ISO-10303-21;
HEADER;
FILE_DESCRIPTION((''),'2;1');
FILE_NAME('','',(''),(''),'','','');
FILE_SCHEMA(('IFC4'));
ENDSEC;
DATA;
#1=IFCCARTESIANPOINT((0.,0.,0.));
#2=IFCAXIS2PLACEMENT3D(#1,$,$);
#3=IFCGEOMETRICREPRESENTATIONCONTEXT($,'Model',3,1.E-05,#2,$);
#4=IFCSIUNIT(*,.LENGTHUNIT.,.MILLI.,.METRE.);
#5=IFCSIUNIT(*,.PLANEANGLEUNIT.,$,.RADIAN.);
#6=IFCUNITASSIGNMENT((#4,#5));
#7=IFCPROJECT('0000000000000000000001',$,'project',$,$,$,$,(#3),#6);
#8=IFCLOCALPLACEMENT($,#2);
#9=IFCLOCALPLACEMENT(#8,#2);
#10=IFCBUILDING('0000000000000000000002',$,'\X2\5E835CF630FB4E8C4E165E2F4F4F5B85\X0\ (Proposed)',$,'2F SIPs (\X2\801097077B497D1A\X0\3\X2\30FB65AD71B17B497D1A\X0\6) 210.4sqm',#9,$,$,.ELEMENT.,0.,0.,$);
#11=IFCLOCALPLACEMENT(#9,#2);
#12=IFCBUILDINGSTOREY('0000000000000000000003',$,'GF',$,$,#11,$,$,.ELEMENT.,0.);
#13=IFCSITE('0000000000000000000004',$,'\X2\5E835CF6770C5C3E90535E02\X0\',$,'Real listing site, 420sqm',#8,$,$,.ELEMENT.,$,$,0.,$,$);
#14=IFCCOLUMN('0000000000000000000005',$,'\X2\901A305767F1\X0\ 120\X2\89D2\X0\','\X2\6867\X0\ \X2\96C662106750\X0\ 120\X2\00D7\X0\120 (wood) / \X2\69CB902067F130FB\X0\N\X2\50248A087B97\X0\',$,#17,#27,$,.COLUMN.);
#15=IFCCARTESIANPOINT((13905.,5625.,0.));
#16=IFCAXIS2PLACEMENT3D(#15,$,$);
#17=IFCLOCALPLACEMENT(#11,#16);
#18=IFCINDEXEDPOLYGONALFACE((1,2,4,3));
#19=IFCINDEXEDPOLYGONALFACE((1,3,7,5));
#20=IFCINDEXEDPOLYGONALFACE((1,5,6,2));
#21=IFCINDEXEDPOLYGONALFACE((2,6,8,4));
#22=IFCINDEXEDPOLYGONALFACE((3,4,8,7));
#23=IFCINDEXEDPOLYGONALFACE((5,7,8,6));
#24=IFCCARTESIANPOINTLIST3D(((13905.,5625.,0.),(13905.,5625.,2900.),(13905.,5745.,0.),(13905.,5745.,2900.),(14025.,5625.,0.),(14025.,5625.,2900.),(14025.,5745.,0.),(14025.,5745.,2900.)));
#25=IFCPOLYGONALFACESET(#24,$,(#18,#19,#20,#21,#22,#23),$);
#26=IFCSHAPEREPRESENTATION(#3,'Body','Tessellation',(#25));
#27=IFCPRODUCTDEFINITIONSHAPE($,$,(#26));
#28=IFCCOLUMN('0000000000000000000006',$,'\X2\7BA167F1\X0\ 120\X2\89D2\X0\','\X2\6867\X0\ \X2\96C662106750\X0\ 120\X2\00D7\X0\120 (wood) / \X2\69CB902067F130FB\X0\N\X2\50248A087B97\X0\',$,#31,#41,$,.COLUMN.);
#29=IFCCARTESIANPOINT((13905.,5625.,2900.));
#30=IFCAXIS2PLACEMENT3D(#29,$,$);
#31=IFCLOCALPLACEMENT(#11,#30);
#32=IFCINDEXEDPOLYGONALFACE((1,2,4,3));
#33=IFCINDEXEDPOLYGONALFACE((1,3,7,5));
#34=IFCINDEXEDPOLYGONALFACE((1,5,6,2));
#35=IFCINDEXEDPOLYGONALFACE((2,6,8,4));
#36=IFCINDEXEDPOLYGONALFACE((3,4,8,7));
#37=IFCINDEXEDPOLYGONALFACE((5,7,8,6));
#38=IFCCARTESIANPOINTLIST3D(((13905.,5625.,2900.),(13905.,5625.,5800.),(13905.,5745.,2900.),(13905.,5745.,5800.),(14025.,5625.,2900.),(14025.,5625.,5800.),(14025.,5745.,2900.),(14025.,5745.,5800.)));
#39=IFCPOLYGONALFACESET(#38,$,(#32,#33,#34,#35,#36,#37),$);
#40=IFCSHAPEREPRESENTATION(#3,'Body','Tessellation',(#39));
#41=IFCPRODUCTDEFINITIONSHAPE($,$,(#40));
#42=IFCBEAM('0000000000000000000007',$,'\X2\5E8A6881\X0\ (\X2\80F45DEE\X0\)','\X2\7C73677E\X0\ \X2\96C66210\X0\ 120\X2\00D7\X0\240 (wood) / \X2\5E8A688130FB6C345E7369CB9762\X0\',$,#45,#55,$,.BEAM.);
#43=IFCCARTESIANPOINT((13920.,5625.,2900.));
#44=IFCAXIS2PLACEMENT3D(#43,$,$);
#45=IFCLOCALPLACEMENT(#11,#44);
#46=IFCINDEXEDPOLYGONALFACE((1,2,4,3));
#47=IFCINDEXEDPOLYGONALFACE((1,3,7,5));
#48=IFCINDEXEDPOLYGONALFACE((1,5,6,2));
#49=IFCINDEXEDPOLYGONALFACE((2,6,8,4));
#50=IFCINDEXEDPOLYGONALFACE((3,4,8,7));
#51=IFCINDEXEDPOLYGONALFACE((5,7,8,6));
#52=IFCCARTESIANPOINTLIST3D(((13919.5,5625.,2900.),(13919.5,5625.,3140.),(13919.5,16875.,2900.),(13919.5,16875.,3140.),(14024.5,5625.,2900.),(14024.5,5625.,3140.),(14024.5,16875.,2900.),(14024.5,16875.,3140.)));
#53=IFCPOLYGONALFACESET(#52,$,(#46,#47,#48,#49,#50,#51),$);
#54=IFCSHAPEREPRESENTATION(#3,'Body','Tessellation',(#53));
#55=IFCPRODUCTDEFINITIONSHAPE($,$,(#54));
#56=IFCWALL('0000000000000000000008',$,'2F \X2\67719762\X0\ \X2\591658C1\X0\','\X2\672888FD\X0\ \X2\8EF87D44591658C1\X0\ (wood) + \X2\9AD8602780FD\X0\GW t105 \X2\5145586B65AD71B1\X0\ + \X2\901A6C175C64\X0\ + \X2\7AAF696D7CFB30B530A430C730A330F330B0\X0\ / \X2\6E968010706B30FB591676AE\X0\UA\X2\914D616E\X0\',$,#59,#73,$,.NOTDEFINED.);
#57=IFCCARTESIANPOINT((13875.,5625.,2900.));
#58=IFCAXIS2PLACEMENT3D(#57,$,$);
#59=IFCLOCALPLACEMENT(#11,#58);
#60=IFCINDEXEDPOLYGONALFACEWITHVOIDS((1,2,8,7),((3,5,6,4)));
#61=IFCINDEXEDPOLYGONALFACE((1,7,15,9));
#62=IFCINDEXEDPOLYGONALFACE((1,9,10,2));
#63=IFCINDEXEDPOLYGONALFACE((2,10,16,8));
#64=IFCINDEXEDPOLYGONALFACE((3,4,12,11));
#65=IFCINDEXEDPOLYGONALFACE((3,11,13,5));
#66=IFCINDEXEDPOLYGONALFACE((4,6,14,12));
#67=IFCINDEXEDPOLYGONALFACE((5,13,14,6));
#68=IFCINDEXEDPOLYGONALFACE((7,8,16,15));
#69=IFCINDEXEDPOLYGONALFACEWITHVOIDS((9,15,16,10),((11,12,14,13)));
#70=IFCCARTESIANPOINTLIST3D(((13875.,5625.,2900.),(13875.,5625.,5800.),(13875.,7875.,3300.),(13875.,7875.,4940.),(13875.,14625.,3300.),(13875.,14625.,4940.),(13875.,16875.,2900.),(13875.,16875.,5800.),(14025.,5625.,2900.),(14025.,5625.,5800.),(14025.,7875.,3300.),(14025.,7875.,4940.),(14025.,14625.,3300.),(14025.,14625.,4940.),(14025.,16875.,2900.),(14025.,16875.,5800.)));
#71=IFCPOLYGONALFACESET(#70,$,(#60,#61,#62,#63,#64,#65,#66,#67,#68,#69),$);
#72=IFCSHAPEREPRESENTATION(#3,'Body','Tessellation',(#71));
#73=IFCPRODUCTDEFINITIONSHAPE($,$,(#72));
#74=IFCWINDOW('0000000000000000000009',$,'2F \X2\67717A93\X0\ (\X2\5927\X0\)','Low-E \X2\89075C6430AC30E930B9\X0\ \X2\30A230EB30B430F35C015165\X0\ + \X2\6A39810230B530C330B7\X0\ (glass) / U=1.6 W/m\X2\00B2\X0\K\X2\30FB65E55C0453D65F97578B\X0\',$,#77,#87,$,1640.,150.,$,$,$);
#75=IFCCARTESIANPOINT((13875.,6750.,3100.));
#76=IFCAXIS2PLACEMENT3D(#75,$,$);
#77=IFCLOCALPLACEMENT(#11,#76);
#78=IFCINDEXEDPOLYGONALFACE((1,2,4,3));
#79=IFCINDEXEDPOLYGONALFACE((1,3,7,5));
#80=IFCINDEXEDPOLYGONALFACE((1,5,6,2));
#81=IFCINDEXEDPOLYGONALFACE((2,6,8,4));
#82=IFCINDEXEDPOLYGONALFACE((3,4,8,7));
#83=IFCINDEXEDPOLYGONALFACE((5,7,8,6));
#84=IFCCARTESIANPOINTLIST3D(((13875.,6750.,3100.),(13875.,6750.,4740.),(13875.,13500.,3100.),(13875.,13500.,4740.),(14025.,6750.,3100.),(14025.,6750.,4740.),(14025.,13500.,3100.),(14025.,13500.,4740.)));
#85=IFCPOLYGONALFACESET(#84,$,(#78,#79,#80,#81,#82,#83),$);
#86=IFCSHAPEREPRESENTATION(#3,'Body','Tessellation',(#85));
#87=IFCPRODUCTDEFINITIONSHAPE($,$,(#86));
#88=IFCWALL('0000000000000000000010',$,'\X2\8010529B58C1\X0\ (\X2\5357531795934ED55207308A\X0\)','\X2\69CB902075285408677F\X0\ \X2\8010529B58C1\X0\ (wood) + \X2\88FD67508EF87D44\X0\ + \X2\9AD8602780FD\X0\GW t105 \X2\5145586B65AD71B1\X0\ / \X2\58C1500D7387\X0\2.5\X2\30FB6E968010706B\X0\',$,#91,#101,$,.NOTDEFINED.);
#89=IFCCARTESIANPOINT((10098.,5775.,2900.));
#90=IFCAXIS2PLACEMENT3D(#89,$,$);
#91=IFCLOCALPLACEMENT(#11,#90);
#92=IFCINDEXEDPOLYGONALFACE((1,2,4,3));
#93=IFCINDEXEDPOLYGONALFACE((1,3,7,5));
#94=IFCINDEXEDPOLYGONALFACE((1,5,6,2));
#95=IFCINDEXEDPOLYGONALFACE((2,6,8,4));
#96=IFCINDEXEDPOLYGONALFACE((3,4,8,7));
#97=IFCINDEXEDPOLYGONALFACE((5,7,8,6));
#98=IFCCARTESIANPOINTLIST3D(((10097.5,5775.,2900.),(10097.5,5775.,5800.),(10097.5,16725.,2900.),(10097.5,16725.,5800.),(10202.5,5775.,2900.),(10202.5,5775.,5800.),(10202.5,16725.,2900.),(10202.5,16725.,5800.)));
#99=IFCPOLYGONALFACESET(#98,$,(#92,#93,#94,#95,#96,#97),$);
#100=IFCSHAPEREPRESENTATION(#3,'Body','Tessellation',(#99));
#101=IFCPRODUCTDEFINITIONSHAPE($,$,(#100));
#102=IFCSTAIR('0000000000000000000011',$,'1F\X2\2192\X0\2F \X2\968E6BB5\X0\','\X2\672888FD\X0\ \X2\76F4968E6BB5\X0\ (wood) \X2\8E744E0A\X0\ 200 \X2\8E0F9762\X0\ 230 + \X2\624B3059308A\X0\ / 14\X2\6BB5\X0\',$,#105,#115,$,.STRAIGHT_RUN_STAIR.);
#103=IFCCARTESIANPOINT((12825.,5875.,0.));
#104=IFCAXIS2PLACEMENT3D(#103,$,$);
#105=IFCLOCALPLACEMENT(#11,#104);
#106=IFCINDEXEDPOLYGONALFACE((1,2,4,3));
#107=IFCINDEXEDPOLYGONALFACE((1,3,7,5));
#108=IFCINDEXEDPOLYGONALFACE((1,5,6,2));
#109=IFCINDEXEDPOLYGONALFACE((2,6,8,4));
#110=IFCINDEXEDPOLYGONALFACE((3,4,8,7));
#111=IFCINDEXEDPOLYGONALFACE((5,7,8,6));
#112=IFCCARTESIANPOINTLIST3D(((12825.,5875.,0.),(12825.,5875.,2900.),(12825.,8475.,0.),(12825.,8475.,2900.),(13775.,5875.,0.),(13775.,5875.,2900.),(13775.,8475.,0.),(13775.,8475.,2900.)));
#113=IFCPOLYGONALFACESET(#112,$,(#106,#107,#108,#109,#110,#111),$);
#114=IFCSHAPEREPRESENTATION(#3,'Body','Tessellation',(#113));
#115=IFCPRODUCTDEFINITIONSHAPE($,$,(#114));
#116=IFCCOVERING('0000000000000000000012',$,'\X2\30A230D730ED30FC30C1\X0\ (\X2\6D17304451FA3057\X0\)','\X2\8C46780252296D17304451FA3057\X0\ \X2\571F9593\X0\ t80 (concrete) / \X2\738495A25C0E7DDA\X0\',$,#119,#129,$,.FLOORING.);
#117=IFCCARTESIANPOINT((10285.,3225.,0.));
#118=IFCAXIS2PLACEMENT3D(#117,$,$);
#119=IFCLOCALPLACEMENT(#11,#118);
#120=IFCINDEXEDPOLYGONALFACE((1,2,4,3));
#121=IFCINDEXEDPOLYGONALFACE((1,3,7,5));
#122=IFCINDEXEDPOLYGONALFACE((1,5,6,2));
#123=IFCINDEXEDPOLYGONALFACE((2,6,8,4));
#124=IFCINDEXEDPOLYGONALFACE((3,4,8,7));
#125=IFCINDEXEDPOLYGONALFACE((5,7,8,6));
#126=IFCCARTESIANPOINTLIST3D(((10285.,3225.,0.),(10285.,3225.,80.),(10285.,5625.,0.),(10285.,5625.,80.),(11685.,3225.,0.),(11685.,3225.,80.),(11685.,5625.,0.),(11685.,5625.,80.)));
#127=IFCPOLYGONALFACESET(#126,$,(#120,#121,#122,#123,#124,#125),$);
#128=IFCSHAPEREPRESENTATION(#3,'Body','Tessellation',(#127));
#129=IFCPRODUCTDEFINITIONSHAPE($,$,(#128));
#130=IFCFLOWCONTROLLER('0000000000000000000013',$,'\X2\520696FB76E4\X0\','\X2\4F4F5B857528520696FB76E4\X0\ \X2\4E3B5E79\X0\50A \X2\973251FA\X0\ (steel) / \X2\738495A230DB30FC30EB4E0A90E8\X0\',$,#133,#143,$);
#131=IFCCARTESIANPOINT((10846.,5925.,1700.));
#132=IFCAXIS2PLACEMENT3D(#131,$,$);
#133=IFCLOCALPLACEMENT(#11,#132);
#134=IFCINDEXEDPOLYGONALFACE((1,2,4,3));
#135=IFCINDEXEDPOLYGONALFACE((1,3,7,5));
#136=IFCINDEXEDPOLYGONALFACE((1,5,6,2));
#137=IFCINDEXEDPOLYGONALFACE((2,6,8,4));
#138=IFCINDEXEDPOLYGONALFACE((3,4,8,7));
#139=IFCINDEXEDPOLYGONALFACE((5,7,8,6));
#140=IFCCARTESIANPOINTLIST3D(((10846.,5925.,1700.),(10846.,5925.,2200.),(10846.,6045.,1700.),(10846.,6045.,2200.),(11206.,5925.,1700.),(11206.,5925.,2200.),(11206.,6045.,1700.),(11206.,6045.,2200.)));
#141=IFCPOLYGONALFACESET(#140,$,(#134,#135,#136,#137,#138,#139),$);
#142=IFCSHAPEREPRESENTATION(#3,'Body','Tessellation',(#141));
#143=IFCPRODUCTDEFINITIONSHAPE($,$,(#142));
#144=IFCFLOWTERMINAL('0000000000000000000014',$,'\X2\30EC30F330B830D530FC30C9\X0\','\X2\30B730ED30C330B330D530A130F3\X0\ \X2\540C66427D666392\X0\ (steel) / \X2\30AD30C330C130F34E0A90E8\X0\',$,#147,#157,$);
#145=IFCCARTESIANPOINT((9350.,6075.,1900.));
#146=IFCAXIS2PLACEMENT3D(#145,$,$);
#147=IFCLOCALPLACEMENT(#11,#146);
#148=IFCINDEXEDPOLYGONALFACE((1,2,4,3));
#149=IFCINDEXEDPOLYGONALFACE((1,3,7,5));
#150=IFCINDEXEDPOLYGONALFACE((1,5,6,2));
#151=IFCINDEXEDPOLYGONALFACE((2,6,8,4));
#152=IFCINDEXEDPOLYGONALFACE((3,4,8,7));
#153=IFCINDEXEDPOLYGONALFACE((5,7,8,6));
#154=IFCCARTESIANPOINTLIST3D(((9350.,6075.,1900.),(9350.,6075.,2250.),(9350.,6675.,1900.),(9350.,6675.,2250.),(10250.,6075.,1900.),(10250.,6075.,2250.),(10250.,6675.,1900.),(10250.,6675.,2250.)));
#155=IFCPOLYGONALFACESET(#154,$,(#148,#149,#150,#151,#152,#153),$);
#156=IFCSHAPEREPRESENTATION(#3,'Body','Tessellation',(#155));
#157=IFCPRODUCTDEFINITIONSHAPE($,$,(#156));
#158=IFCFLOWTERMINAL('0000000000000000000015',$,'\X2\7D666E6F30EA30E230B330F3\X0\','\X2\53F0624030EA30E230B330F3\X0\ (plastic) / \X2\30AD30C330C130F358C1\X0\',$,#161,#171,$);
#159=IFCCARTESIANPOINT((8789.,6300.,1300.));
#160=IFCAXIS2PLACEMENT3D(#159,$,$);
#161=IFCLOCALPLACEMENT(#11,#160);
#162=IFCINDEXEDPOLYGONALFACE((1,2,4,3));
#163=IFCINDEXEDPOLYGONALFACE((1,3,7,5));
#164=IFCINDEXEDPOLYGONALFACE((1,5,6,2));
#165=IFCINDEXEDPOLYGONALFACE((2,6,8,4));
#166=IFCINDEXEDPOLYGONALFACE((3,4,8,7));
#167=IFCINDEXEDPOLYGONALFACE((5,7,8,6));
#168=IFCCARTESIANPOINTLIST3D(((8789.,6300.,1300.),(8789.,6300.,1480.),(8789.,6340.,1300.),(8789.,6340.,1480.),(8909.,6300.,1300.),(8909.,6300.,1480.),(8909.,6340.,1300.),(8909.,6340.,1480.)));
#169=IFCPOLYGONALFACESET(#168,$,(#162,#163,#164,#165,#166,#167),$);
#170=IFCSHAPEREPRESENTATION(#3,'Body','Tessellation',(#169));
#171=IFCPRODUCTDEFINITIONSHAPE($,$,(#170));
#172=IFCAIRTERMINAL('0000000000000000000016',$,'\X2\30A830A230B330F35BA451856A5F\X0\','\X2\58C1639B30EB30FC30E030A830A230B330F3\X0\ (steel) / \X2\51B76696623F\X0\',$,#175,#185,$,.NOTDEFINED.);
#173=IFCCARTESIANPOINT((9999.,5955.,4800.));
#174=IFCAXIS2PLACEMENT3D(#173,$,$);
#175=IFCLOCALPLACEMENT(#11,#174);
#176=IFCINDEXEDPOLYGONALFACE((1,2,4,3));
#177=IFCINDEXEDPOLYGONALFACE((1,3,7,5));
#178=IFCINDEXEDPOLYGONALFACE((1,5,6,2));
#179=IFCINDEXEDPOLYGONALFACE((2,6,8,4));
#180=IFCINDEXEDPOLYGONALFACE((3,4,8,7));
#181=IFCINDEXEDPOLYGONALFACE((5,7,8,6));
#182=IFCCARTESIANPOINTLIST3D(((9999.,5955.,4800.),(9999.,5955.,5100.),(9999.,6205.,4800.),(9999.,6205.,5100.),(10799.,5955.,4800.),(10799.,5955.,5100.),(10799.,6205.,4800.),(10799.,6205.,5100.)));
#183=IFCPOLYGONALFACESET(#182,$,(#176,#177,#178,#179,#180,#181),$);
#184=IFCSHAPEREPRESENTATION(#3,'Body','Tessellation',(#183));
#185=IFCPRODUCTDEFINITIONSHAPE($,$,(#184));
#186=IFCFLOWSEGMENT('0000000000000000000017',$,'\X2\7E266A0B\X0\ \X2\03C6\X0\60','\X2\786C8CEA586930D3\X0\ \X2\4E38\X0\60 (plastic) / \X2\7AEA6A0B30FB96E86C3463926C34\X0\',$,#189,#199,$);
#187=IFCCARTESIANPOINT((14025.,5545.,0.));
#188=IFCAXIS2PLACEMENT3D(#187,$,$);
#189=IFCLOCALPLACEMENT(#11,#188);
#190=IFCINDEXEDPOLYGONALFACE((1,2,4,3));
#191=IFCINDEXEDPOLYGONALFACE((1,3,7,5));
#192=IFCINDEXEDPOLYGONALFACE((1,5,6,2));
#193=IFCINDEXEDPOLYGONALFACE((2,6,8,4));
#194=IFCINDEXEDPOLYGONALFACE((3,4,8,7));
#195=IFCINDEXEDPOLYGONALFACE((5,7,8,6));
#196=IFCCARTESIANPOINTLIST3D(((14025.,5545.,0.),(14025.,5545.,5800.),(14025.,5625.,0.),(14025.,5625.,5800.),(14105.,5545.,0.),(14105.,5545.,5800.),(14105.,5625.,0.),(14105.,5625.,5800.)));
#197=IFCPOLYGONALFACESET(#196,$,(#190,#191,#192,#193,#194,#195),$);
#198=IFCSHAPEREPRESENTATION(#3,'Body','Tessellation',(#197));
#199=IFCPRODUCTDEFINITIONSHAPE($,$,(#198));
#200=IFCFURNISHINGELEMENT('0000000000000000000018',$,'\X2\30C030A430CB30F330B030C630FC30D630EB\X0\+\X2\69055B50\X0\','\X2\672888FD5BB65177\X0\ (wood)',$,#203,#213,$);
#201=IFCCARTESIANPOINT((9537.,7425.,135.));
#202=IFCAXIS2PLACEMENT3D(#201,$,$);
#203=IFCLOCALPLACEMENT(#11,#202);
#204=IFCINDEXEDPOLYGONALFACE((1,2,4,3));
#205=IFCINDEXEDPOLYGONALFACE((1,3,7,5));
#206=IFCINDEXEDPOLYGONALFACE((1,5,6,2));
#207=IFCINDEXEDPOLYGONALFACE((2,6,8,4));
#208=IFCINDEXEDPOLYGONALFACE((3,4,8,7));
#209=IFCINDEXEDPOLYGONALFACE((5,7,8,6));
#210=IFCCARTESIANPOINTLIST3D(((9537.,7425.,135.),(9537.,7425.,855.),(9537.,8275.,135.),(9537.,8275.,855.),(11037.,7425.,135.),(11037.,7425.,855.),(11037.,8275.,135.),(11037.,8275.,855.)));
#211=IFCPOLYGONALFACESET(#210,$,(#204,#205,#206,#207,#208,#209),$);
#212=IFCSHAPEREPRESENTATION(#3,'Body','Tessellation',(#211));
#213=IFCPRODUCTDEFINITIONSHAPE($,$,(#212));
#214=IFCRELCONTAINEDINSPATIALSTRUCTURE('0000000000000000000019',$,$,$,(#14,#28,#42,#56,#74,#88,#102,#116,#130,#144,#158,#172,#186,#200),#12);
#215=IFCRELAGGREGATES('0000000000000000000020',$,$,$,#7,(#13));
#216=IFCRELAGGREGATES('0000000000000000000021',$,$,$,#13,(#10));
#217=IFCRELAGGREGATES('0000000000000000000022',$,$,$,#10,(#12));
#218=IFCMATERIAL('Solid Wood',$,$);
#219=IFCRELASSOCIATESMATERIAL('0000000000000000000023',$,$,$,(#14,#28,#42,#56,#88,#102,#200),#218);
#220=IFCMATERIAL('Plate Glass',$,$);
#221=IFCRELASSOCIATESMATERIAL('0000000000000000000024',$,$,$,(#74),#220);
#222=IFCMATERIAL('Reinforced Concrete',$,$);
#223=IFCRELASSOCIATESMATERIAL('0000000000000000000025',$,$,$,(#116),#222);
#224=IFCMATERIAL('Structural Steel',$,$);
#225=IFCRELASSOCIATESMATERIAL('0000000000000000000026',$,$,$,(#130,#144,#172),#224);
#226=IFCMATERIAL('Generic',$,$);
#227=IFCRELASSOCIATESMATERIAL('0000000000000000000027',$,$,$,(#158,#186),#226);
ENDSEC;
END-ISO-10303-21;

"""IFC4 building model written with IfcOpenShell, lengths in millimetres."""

from ifc_helpers import new_model, si_unit, frame, frame_2d, origin, place, context, project, spatial, rectangle, extrude, material, element, fill, save


model = new_model("IFC4")

# Units and contexts
model_context = context("Model", 3, precision=1e-05, world=origin())
ifc_project = project(units=[si_unit("LENGTHUNIT", "METRE", prefix="MILLI"), si_unit("PLANEANGLEUNIT", "RADIAN")], contexts=[model_context])

# Site, building, storey
site_placement = place(None, origin())
site = spatial("IfcSite", under=ifc_project, at=site_placement, Name="広島県尾道市", ObjectType="Real listing site, 420sqm", CompositionType="ELEMENT", RefElevation=0.0)
building_placement = place(site_placement, origin())
building = spatial("IfcBuilding", under=site, at=building_placement, Name="広島・二世帯住宅 (Proposed)", ObjectType="2F SIPs (耐震等級3・断熱等級6) 210.4sqm", CompositionType="ELEMENT", ElevationOfRefHeight=0.0, ElevationOfTerrain=0.0)
storey_placement = place(building_placement, origin())
storey = spatial("IfcBuildingStorey", under=building, at=storey_placement, Name="GF", CompositionType="ELEMENT", Elevation=0.0)

# Columns
ifc_material_1 = material(Name="Solid Wood")
column_1_placement = place(storey_placement, frame((13905.0, 5625.0, 0.0)))
element("IfcColumn", 1, at=column_1_placement, inside=storey, material=ifc_material_1, Name="通し柱 120角", Description="桧 集成材 120×120 (wood) / 構造柱・N値計算", PredefinedType="COLUMN", context=model_context, shape_type="SweptSolid", body=[
    extrude(rectangle(XDim=120.0, YDim=120.0, at=frame_2d((60.0, 60.0))), frame((13905.0, 5625.0, 0.0)), (0.0, 0.0, 1.0), 2900.0),
])
column_2_placement = place(storey_placement, frame((13905.0, 5625.0, 2900.0)))
element("IfcColumn", 2, at=column_2_placement, inside=storey, material=ifc_material_1, Name="管柱 120角", Description="桧 集成材 120×120 (wood) / 構造柱・N値計算", PredefinedType="COLUMN", context=model_context, shape_type="SweptSolid", body=[
    extrude(rectangle(XDim=120.0, YDim=120.0, at=frame_2d((60.0, 60.0))), frame((13905.0, 5625.0, 2900.0)), (0.0, 0.0, 1.0), 2900.0),
])

# Beam
beam_1_placement = place(storey_placement, frame((13920.0, 5625.0, 2900.0)))
element("IfcBeam", 3, at=beam_1_placement, inside=storey, material=ifc_material_1, Name="床梁 (胴差)", Description="米松 集成 120×240 (wood) / 床梁・水平構面", PredefinedType="BEAM", context=model_context, shape_type="SweptSolid", body=[
    extrude(rectangle(XDim=105.0, YDim=11250.0, at=frame_2d((52.0, 5625.0))), frame((13920.0, 5625.0, 2900.0)), (0.0, 0.0, 1.0), 240.0),
])

# Shared definitions
ifc_material_2 = material(Name="Plate Glass")

# Wall, opening, window
wall_1_placement = place(storey_placement, frame((13875.0, 5625.0, 2900.0)))
wall_1 = element("IfcWall", 4, at=wall_1_placement, inside=storey, material=ifc_material_1, Name="2F 東面 外壁", Description="木製 軸組外壁 (wood) + 高性能GW t105 充填断熱 + 通気層 + 窯業系サイディング / 準耐火・外皮UA配慮", PredefinedType="NOTDEFINED", context=model_context, shape_type="SweptSolid", body=[
    extrude(rectangle(XDim=150.0, YDim=11250.0, at=frame_2d((75.0, 5625.0))), frame((13875.0, 5625.0, 2900.0)), (0.0, 0.0, 1.0), 2900.0),
])
opening_1_placement = place(storey_placement, frame((13875.0, 6750.0, 3100.0)))
opening_1 = element("IfcOpeningElement", 5, at=opening_1_placement, cuts=wall_1, PredefinedType="NOTDEFINED", context=model_context, shape_type="SweptSolid", body=[
    extrude(rectangle(XDim=150.0, YDim=6750.0, at=frame_2d((75.0, 3375.0))), frame((13875.0, 6750.0, 3100.0)), (0.0, 0.0, 1.0), 1640.0),
])
window_1_placement = place(storey_placement, frame((13875.0, 6750.0, 3100.0)))
window_1 = element("IfcWindow", 6, at=window_1_placement, inside=storey, material=ifc_material_2, Name="2F 東窓 (大)", Description="Low-E 複層ガラス アルゴン封入 + 樹脂サッシ (glass) / U=1.6 W/m²K・日射取得型", OverallHeight=1640.0, OverallWidth=150.0, context=model_context, shape_type="SweptSolid", body=[
    extrude(rectangle(XDim=150.0, YDim=6750.0, at=frame_2d((75.0, 3375.0))), frame((13875.0, 6750.0, 3100.0)), (0.0, 0.0, 1.0), 1640.0),
])
fill(opening_1, window_1)

# Wall
wall_2_placement = place(storey_placement, frame((10098.0, 5775.0, 2900.0)))
element("IfcWall", 7, at=wall_2_placement, inside=storey, material=ifc_material_1, Name="耐力壁 (南北間仕切り)", Description="構造用合板 耐力壁 (wood) + 製材軸組 + 高性能GW t105 充填断熱 / 壁倍率2.5・準耐火", PredefinedType="NOTDEFINED", context=model_context, shape_type="SweptSolid", body=[
    extrude(rectangle(XDim=105.0, YDim=10950.0, at=frame_2d((52.0, 5475.0))), frame((10098.0, 5775.0, 2900.0)), (0.0, 0.0, 1.0), 2900.0),
])

# Stair
stair_placement = place(storey_placement, frame((12825.0, 5875.0, 0.0)))
element("IfcStair", 8, at=stair_placement, inside=storey, material=ifc_material_1, Name="1F→2F 階段", Description="木製 直階段 (wood) 蹴上 200 踏面 230 + 手すり / 14段", PredefinedType="STRAIGHT_RUN_STAIR", context=model_context, shape_type="SweptSolid", body=[
    extrude(rectangle(XDim=950.0, YDim=2600.0, at=frame_2d((475.0, 1300.0))), frame((12825.0, 5875.0, 0.0)), (0.0, 0.0, 1.0), 2900.0),
])

# Covering
ifc_material_3 = material(Name="Reinforced Concrete")
covering_placement = place(storey_placement, frame((10285.0, 3225.0, 0.0)))
element("IfcCovering", 9, at=covering_placement, inside=storey, material=ifc_material_3, Name="アプローチ (洗い出し)", Description="豆砂利洗い出し 土間 t80 (concrete) / 玄関導線", PredefinedType="FLOORING", context=model_context, shape_type="SweptSolid", body=[
    extrude(rectangle(XDim=1400.0, YDim=2400.0, at=frame_2d((700.0, 1200.0))), frame((10285.0, 3225.0, 0.0)), (0.0, 0.0, 1.0), 80.0),
])

# Flow controller
ifc_material_4 = material(Name="Structural Steel")
flow_controller_placement = place(storey_placement, frame((10846.0, 5925.0, 1700.0)))
element("IfcFlowController", 10, at=flow_controller_placement, inside=storey, material=ifc_material_4, Name="分電盤", Description="住宅用分電盤 主幹50A 露出 (steel) / 玄関ホール上部", context=model_context, shape_type="SweptSolid", body=[
    extrude(rectangle(XDim=360.0, YDim=120.0, at=frame_2d((180.0, 60.0))), frame((10846.0, 5925.0, 1700.0)), (0.0, 0.0, 1.0), 500.0),
])

# Flow terminals
flow_terminal_1_placement = place(storey_placement, frame((9350.0, 6075.0, 1900.0)))
element("IfcFlowTerminal", 11, at=flow_terminal_1_placement, inside=storey, material=ifc_material_4, Name="レンジフード", Description="シロッコファン 同時給排 (steel) / キッチン上部", context=model_context, shape_type="SweptSolid", body=[
    extrude(rectangle(XDim=900.0, YDim=600.0, at=frame_2d((450.0, 300.0))), frame((9350.0, 6075.0, 1900.0)), (0.0, 0.0, 1.0), 350.0),
])
ifc_material_5 = material(Name="Generic")
flow_terminal_2_placement = place(storey_placement, frame((8789.0, 6300.0, 1300.0)))
element("IfcFlowTerminal", 12, at=flow_terminal_2_placement, inside=storey, material=ifc_material_5, Name="給湯リモコン", Description="台所リモコン (plastic) / キッチン壁", context=model_context, shape_type="SweptSolid", body=[
    extrude(rectangle(XDim=120.0, YDim=40.0, at=frame_2d((60.0, 20.0))), frame((8789.0, 6300.0, 1300.0)), (0.0, 0.0, 1.0), 180.0),
])

# Air terminal
air_terminal_placement = place(storey_placement, frame((9999.0, 5955.0, 4800.0)))
element("IfcAirTerminal", 13, at=air_terminal_placement, inside=storey, material=ifc_material_4, Name="エアコン室内機", Description="壁掛ルームエアコン (steel) / 冷暖房", PredefinedType="NOTDEFINED", context=model_context, shape_type="SweptSolid", body=[
    extrude(rectangle(XDim=800.0, YDim=250.0, at=frame_2d((400.0, 125.0))), frame((9999.0, 5955.0, 4800.0)), (0.0, 0.0, 1.0), 300.0),
])

# Flow segment
flow_segment_placement = place(storey_placement, frame((14025.0, 5545.0, 0.0)))
element("IfcFlowSegment", 14, at=flow_segment_placement, inside=storey, material=ifc_material_5, Name="縦樋 φ60", Description="硬質塩ビ 丸60 (plastic) / 竪樋・雨水排水", context=model_context, shape_type="SweptSolid", body=[
    extrude(rectangle(XDim=80.0, YDim=80.0, at=frame_2d((40.0, 40.0))), frame((14025.0, 5545.0, 0.0)), (0.0, 0.0, 1.0), 5800.0),
])

# Furnishing element
furnishing_1_placement = place(storey_placement, frame((9537.0, 7425.0, 135.0)))
element("IfcFurnishingElement", 15, at=furnishing_1_placement, inside=storey, material=ifc_material_1, Name="ダイニングテーブル+椅子", Description="木製家具 (wood)", context=model_context, shape_type="SweptSolid", body=[
    extrude(rectangle(XDim=1500.0, YDim=850.0, at=frame_2d((750.0, 425.0))), frame((9537.0, 7425.0, 135.0)), (0.0, 0.0, 1.0), 720.0),
])

save(model, "model.ifc")
